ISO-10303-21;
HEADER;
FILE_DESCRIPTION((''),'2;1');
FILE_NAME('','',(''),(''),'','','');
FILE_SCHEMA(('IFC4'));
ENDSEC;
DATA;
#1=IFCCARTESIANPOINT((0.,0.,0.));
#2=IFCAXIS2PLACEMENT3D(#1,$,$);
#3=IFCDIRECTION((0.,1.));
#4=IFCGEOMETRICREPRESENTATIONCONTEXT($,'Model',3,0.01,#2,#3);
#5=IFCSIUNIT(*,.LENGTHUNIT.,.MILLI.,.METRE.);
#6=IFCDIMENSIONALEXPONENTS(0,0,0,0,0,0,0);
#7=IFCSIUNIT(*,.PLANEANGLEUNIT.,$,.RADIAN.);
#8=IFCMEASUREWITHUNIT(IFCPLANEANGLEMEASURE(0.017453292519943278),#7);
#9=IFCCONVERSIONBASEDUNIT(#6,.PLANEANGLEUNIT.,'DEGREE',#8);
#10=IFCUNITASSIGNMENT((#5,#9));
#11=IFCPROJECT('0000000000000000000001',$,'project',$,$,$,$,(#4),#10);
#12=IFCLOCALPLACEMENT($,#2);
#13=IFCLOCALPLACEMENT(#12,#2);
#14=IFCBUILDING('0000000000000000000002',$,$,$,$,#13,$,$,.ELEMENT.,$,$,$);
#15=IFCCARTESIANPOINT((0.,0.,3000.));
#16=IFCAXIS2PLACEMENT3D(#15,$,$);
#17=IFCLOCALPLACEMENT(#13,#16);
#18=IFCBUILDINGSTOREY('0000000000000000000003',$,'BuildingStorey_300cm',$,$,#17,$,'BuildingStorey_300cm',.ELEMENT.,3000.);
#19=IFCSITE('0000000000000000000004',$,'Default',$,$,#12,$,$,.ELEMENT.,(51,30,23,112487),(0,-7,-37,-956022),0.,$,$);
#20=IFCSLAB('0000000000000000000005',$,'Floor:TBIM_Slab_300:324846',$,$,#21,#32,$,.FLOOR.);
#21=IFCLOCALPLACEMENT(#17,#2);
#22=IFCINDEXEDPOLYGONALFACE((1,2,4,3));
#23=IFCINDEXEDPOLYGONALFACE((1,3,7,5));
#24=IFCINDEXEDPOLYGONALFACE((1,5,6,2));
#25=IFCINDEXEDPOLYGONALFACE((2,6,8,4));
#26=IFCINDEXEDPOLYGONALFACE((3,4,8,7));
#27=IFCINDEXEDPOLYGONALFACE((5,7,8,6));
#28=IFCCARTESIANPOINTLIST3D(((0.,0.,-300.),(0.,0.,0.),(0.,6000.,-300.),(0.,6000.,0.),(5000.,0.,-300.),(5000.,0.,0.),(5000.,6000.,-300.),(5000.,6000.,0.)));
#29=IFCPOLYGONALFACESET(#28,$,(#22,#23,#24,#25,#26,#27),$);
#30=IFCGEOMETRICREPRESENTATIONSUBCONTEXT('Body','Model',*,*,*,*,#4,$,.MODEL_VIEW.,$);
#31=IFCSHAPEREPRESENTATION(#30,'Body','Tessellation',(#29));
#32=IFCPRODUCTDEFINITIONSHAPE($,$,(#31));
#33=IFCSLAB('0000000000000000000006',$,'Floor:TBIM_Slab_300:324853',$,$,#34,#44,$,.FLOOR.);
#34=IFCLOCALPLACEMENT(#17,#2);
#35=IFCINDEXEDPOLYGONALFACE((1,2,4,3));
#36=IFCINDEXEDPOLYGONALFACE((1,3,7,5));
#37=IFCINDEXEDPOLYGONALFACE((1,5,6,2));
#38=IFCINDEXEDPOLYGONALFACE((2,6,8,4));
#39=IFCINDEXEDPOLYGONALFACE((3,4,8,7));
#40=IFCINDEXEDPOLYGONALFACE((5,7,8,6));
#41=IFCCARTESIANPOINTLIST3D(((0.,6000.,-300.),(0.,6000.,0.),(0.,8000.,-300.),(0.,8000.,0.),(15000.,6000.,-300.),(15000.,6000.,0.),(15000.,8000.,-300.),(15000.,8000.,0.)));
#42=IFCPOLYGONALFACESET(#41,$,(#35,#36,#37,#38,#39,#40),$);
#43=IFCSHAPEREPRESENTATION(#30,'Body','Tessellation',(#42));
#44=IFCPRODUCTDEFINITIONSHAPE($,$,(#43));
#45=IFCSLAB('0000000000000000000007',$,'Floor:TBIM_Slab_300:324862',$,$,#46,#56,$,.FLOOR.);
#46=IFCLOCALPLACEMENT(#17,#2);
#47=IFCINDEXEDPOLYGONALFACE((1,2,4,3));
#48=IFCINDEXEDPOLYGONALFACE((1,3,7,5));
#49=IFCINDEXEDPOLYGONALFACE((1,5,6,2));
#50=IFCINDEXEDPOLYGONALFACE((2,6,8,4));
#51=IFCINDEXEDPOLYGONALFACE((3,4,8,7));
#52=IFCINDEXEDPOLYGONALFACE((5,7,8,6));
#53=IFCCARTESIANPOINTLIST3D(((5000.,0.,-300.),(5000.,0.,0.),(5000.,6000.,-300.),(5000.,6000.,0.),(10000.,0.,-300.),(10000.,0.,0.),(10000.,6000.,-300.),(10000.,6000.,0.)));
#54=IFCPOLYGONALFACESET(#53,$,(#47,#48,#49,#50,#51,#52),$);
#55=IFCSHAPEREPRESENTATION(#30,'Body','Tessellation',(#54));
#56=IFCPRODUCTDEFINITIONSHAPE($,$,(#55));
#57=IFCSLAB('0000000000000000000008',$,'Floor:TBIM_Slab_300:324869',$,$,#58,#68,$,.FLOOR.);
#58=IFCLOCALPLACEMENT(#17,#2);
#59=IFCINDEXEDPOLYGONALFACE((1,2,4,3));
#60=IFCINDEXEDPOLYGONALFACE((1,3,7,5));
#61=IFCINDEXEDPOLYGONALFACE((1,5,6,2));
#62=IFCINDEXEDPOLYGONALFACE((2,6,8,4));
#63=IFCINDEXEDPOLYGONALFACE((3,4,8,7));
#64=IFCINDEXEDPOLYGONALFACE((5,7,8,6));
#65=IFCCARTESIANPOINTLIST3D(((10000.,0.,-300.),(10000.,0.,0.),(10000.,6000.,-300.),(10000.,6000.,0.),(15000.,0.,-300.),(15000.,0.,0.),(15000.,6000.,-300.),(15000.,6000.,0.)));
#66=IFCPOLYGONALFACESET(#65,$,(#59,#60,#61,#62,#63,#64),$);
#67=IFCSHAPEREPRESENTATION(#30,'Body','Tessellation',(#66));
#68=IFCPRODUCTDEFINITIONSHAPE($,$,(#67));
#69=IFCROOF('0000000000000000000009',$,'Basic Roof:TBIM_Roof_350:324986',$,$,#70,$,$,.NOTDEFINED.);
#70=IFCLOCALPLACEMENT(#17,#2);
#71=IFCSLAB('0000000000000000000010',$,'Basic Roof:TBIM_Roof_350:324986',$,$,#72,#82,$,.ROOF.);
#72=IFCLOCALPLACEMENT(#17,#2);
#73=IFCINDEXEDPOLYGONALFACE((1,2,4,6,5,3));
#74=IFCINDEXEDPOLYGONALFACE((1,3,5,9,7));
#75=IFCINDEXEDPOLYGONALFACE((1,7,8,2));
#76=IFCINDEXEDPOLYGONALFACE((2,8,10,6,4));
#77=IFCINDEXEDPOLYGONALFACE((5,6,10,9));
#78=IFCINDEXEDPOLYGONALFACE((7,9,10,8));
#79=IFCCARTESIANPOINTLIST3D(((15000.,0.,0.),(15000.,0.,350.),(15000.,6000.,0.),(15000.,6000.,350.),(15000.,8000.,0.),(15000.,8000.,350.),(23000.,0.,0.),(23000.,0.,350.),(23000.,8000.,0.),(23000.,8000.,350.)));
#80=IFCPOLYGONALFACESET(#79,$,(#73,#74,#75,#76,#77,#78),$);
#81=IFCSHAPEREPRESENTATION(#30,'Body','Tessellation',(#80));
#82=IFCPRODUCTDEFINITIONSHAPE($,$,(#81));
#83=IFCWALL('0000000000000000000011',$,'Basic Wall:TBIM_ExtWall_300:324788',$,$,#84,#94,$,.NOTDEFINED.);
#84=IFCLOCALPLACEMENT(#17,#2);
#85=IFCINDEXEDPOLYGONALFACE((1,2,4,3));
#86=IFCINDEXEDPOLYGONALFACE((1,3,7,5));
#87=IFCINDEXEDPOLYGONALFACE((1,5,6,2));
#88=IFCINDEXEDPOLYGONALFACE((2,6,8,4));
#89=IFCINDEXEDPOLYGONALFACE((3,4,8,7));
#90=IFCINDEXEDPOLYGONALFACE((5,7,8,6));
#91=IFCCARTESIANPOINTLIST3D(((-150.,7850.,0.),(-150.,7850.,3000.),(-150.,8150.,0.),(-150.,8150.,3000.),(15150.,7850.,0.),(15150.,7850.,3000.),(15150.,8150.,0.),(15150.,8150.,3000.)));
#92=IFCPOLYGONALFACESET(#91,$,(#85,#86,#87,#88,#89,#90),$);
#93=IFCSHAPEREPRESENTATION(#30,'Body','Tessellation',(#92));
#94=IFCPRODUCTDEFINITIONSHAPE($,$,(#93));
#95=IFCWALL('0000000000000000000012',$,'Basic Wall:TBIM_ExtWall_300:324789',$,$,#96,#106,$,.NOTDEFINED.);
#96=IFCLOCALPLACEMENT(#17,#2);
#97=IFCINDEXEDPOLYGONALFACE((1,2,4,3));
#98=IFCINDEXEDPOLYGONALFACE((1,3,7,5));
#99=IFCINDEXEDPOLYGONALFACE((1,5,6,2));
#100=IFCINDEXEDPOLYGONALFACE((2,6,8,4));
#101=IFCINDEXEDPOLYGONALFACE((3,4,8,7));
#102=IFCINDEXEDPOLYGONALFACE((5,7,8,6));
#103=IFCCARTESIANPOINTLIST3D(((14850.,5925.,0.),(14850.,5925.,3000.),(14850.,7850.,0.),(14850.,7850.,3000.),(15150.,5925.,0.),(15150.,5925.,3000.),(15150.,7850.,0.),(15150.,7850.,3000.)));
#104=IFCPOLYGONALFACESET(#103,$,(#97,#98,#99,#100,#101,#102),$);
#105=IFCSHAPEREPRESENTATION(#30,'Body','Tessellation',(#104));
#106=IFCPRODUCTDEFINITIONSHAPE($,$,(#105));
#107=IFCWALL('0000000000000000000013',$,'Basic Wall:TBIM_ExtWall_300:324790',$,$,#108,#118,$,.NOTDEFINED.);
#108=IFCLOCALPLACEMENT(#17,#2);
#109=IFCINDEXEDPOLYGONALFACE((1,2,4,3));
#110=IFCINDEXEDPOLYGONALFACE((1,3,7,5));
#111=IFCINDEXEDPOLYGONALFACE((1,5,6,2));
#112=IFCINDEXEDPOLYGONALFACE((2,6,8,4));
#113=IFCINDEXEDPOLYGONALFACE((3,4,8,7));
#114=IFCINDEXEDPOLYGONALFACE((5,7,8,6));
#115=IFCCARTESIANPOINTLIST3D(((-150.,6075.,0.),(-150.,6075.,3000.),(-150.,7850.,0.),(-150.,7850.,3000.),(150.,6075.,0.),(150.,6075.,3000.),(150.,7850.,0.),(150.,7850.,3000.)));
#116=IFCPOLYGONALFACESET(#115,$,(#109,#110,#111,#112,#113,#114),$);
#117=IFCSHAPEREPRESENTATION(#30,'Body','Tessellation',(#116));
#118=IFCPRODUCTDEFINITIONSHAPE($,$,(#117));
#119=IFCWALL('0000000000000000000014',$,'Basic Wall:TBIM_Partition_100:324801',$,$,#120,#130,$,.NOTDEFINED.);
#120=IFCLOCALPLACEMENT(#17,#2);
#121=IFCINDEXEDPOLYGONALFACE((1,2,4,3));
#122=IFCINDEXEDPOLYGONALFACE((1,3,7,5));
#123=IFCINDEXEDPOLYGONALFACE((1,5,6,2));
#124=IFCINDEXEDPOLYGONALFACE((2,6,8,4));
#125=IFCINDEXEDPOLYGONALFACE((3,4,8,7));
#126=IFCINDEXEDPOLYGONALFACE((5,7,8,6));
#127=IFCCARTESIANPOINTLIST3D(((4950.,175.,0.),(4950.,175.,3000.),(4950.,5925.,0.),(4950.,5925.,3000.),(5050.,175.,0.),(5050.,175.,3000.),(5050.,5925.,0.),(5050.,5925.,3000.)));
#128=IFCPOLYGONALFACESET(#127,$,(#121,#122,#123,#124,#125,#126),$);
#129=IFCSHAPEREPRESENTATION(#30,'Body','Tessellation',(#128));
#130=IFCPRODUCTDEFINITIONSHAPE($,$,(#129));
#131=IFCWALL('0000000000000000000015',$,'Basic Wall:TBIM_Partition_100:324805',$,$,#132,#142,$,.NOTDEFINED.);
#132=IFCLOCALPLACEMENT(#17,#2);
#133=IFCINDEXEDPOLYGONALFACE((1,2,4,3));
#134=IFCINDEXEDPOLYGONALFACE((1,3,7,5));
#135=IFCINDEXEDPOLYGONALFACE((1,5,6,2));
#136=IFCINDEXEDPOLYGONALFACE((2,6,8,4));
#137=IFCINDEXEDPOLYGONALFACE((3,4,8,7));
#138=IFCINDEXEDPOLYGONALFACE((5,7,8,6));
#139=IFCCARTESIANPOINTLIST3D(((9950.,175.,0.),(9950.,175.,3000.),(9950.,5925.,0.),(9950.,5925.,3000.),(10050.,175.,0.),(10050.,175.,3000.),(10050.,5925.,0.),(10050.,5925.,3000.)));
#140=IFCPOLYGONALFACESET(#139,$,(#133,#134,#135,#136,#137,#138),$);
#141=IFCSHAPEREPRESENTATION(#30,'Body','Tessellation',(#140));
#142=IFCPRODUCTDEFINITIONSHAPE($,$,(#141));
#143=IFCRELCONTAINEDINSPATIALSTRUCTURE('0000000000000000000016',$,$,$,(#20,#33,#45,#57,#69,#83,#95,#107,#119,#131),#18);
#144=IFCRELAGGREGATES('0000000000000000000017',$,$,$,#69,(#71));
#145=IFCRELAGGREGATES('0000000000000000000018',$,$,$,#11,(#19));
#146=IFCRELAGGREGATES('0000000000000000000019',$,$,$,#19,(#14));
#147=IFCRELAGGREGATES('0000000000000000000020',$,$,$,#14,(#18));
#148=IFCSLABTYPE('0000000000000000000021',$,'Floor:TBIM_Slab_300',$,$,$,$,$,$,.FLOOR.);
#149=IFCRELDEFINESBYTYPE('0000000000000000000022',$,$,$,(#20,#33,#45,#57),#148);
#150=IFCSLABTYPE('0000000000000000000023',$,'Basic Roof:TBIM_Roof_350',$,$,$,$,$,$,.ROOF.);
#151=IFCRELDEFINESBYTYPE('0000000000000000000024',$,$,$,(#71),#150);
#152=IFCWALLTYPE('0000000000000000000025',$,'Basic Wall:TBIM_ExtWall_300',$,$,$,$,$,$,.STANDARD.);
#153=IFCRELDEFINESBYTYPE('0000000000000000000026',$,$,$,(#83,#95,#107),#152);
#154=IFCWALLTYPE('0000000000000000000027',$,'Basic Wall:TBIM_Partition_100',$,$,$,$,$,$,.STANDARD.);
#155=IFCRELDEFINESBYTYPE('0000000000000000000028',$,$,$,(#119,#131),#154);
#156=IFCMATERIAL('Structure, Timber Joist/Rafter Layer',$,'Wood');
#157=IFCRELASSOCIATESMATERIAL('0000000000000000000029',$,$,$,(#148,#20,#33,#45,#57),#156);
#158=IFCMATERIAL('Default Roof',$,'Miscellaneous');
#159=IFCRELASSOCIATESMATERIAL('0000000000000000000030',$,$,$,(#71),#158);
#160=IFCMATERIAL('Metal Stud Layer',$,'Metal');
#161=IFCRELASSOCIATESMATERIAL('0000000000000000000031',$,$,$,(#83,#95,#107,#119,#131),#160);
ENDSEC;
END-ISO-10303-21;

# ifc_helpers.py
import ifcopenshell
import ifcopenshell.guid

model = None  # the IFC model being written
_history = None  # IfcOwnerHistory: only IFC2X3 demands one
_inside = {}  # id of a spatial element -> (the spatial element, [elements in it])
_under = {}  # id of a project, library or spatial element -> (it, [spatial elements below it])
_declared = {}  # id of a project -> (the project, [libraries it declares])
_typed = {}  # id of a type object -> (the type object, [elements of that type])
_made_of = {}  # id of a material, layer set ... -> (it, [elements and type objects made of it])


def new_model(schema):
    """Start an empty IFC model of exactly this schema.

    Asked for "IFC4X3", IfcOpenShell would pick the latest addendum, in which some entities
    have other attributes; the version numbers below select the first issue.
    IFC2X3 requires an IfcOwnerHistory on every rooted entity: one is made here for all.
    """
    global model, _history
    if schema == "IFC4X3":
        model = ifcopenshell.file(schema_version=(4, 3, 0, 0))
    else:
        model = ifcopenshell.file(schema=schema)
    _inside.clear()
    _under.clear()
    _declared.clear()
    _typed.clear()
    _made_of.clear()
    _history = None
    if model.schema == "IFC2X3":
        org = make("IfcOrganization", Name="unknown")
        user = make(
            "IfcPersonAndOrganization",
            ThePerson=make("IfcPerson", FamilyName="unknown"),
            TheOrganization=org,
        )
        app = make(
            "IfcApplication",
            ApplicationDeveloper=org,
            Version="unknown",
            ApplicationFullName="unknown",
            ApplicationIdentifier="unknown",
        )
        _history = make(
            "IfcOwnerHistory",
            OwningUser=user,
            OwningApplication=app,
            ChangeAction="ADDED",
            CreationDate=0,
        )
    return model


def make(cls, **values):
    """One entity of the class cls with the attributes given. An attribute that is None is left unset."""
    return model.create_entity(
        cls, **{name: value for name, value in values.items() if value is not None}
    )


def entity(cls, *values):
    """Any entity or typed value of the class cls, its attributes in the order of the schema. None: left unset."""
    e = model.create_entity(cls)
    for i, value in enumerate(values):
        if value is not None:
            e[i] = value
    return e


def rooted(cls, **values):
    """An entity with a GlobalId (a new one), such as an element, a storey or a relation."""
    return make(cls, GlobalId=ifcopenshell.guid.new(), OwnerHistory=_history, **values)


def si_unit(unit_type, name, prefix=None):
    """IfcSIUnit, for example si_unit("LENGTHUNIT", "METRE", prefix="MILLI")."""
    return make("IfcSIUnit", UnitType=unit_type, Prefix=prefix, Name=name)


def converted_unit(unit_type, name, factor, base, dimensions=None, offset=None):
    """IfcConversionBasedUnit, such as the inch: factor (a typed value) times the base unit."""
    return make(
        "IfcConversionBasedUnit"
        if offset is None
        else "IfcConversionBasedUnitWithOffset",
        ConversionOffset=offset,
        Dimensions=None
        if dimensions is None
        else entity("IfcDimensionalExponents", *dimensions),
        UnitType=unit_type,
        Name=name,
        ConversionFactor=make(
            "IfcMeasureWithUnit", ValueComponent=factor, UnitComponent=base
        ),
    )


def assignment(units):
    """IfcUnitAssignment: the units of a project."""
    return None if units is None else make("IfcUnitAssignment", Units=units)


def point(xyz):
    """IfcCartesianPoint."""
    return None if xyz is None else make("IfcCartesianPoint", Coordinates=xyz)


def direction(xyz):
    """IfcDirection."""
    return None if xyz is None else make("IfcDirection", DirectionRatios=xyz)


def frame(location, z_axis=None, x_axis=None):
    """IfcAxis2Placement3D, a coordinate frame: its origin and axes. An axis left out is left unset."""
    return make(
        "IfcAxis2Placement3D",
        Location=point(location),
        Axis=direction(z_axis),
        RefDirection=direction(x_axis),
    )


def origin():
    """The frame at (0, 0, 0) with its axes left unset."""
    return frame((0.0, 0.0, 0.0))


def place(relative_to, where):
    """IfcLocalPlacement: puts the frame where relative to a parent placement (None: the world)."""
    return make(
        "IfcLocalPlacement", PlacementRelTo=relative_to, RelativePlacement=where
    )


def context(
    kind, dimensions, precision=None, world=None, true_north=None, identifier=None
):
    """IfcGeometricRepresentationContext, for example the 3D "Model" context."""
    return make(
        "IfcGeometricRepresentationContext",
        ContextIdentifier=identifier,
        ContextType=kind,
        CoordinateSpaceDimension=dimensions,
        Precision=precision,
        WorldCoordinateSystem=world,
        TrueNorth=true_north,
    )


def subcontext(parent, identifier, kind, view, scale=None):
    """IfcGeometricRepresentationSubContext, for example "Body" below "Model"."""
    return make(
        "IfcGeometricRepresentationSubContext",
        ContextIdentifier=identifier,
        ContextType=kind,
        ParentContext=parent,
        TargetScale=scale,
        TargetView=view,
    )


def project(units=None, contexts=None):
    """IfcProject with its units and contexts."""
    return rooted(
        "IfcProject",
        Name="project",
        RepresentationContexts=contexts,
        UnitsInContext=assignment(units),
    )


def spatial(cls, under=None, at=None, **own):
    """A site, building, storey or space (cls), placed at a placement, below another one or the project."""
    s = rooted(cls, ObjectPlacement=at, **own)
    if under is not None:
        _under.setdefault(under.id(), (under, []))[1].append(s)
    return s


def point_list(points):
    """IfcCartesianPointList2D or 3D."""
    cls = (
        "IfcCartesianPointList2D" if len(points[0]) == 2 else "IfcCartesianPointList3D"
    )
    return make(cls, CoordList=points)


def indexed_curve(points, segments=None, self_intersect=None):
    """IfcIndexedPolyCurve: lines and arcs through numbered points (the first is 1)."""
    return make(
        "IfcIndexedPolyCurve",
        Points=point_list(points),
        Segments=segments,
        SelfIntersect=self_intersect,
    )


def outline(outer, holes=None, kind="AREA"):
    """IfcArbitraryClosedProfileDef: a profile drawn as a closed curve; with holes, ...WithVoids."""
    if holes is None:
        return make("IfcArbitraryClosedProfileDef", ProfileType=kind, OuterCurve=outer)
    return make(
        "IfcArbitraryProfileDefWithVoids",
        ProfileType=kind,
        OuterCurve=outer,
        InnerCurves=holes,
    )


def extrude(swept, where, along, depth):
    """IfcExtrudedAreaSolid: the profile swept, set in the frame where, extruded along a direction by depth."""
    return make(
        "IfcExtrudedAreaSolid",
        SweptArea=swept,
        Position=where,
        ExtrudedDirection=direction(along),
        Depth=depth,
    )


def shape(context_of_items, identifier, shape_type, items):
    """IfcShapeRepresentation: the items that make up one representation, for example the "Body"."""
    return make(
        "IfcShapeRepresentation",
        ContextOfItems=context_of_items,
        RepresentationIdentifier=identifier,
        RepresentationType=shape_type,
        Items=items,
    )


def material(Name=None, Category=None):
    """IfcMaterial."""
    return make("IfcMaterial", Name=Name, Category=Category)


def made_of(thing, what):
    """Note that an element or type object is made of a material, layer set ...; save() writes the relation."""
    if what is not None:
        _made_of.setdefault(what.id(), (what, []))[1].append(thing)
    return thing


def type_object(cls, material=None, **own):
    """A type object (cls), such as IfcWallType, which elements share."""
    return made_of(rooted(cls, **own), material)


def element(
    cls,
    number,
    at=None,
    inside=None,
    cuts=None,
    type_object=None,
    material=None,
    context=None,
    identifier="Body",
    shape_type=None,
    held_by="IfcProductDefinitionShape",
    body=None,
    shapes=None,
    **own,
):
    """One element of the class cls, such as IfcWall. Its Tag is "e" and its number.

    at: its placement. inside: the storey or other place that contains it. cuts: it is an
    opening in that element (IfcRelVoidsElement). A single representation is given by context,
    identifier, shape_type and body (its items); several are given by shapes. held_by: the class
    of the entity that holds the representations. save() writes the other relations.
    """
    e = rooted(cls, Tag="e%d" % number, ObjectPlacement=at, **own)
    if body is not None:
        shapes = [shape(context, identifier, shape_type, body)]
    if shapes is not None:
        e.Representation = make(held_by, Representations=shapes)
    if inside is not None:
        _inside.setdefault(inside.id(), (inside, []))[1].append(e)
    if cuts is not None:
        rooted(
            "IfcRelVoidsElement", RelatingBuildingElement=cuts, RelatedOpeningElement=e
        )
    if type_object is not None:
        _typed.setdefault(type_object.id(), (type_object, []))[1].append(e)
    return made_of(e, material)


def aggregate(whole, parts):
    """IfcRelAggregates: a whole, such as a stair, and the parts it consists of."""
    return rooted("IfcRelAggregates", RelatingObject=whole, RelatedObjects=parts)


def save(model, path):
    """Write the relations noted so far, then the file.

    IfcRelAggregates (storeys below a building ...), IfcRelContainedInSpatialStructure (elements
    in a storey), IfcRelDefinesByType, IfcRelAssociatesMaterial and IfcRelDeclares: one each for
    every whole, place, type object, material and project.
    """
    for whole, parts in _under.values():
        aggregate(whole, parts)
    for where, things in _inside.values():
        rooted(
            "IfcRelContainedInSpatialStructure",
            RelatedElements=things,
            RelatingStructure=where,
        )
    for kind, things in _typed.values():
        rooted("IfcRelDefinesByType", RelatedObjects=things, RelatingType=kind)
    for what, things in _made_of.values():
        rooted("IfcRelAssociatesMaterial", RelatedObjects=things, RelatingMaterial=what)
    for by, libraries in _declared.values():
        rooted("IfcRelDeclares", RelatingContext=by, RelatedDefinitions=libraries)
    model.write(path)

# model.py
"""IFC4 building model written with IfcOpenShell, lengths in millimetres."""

from ifc_helpers import new_model, entity, si_unit, converted_unit, direction, frame, origin, place, context, subcontext, project, spatial, indexed_curve, outline, extrude, material, type_object, element, aggregate, save


model = new_model("IFC4")

# Units and contexts
model_context = context("Model", 3, precision=0.01, world=origin(), true_north=direction((0.0, 1.0)))
body_context = subcontext(model_context, "Body", "Model", "MODEL_VIEW")
ifc_project = project(units=[si_unit("LENGTHUNIT", "METRE", prefix="MILLI"), converted_unit("PLANEANGLEUNIT", "DEGREE", entity("IfcPlaneAngleMeasure", 0.017453292519943278), si_unit("PLANEANGLEUNIT", "RADIAN"), dimensions=[0, 0, 0, 0, 0, 0, 0])], contexts=[model_context])

# Site, building, storey
site_placement = place(None, origin())
site = spatial("IfcSite", under=ifc_project, at=site_placement, Name="Default", CompositionType="ELEMENT", RefLatitude=(51, 30, 23, 112487), RefLongitude=(0, -7, -37, -956022), RefElevation=0.0)
building_placement = place(site_placement, origin())
building = spatial("IfcBuilding", under=site, at=building_placement, CompositionType="ELEMENT")
storey_placement = place(building_placement, frame((0.0, 0.0, 3000.0)))
storey = spatial("IfcBuildingStorey", under=building, at=storey_placement, Name="BuildingStorey_300cm", LongName="BuildingStorey_300cm", CompositionType="ELEMENT", Elevation=3000.0)

# Slabs
ifc_material_1 = material(Name="Structure, Timber Joist/Rafter Layer", Category="Wood")
slab_type_1 = type_object("IfcSlabType", Name="Floor:TBIM_Slab_300", PredefinedType="FLOOR", material=ifc_material_1)
slab_1_placement = place(storey_placement, origin())
element("IfcSlab", 1, at=slab_1_placement, inside=storey, type_object=slab_type_1, material=ifc_material_1, Name="Floor:TBIM_Slab_300:324846", PredefinedType="FLOOR", context=body_context, shape_type="SweptSolid", body=[
    extrude(outline(indexed_curve([(-3000.0, -2500.0), (3000.0, -2500.0), (3000.0, 2500.0), (-3000.0, 2500.0), (-3000.0, -2500.0)], self_intersect=False)), frame((2500.0, 3000.0, 0.0), z_axis=(0.0, 0.0, -1.0), x_axis=(0.0, 1.0, 0.0)), (0.0, 0.0, 1.0), 300.0),
])
slab_2_placement = place(storey_placement, origin())
element("IfcSlab", 2, at=slab_2_placement, inside=storey, type_object=slab_type_1, material=ifc_material_1, Name="Floor:TBIM_Slab_300:324853", PredefinedType="FLOOR", context=body_context, shape_type="SweptSolid", body=[
    extrude(outline(indexed_curve([(-1000.0, -7500.0), (1000.0, -7500.0), (1000.0, 7500.0), (-1000.0, 7500.0), (-1000.0, -7500.0)], self_intersect=False)), frame((7500.0, 7000.0, 0.0), z_axis=(0.0, 0.0, -1.0), x_axis=(0.0, 1.0, 0.0)), (0.0, 0.0, 1.0), 300.0),
])
slab_3_placement = place(storey_placement, origin())
element("IfcSlab", 3, at=slab_3_placement, inside=storey, type_object=slab_type_1, material=ifc_material_1, Name="Floor:TBIM_Slab_300:324862", PredefinedType="FLOOR", context=body_context, shape_type="SweptSolid", body=[
    extrude(outline(indexed_curve([(-3000.0, -2500.0), (3000.0, -2500.0), (3000.0, 2500.0), (-3000.0, 2500.0), (-3000.0, -2500.0)], self_intersect=False)), frame((7500.0, 3000.0, 0.0), z_axis=(0.0, 0.0, -1.0), x_axis=(0.0, 1.0, 0.0)), (0.0, 0.0, 1.0), 300.0),
])
slab_4_placement = place(storey_placement, origin())
element("IfcSlab", 4, at=slab_4_placement, inside=storey, type_object=slab_type_1, material=ifc_material_1, Name="Floor:TBIM_Slab_300:324869", PredefinedType="FLOOR", context=body_context, shape_type="SweptSolid", body=[
    extrude(outline(indexed_curve([(-3000.0, -2500.0), (3000.0, -2500.0), (3000.0, 2500.0), (-3000.0, 2500.0), (-3000.0, -2500.0)], self_intersect=False)), frame((12500.0, 3000.0, 0.0), z_axis=(0.0, 0.0, -1.0), x_axis=(0.0, 1.0, 0.0)), (0.0, 0.0, 1.0), 300.0),
])

# Roof, slab
roof_placement = place(storey_placement, frame((15000.0, 0.0, 0.0)))
roof = element("IfcRoof", 5, at=roof_placement, inside=storey, Name="Basic Roof:TBIM_Roof_350:324986", PredefinedType="NOTDEFINED")
ifc_material_2 = material(Name="Default Roof", Category="Miscellaneous")
slab_type_2 = type_object("IfcSlabType", Name="Basic Roof:TBIM_Roof_350", PredefinedType="ROOF")
slab_5_placement = place(roof_placement, origin())
slab_5 = element("IfcSlab", 6, at=slab_5_placement, type_object=slab_type_2, material=ifc_material_2, Name="Basic Roof:TBIM_Roof_350:324986", PredefinedType="ROOF", context=body_context, shape_type="SweptSolid", body=[
    extrude(outline(indexed_curve([(-4000.0, 4000.0), (-4000.0, 2000.0), (-4000.0, -4000.0), (4000.0, -4000.0), (4000.0, 4000.0), (-4000.0, 4000.0)], self_intersect=False)), frame((4000.0, 4000.0, 0.0)), (0.0, 0.0, 1.0), 350.0),
])
aggregate(roof, [slab_5])

# Walls
ifc_material_3 = material(Name="Metal Stud Layer", Category="Metal")
wall_type_1 = type_object("IfcWallType", Name="Basic Wall:TBIM_ExtWall_300", PredefinedType="STANDARD")
wall_1_placement = place(storey_placement, frame((-150.0, 8000.0, 0.0)))
element("IfcWall", 7, at=wall_1_placement, inside=storey, type_object=wall_type_1, material=ifc_material_3, Name="Basic Wall:TBIM_ExtWall_300:324788", PredefinedType="NOTDEFINED", context=body_context, shape_type="SweptSolid", body=[
    extrude(outline(indexed_curve([(15300.0, 150.0), (0.0, 150.0), (0.0, -150.0), (15300.0, -150.0), (15300.0, 150.0)], self_intersect=False)), origin(), (0.0, 0.0, 1.0), 3000.0),
])
wall_2_placement = place(storey_placement, frame((15000.0, 7850.0, 0.0), z_axis=(0.0, 0.0, 1.0), x_axis=(0.0, -1.0, 0.0)))
element("IfcWall", 8, at=wall_2_placement, inside=storey, type_object=wall_type_1, material=ifc_material_3, Name="Basic Wall:TBIM_ExtWall_300:324789", PredefinedType="NOTDEFINED", context=body_context, shape_type="SweptSolid", body=[
    extrude(outline(indexed_curve([(1925.0, 150.0), (0.0, 150.0), (0.0, -150.0), (1925.0, -150.0), (1925.0, 150.0)], self_intersect=False)), origin(), (0.0, 0.0, 1.0), 3000.0),
])
wall_3_placement = place(storey_placement, frame((0.0, 7850.0, 0.0), z_axis=(0.0, 0.0, 1.0), x_axis=(0.0, -1.0, 0.0)))
element("IfcWall", 9, at=wall_3_placement, inside=storey, type_object=wall_type_1, material=ifc_material_3, Name="Basic Wall:TBIM_ExtWall_300:324790", PredefinedType="NOTDEFINED", context=body_context, shape_type="SweptSolid", body=[
    extrude(outline(indexed_curve([(1775.0, 150.0), (0.0, 150.0), (0.0, -150.0), (1775.0, -150.0), (1775.0, 150.0)], self_intersect=False)), origin(), (0.0, 0.0, 1.0), 3000.0),
])
wall_type_2 = type_object("IfcWallType", Name="Basic Wall:TBIM_Partition_100", PredefinedType="STANDARD")
wall_4_placement = place(storey_placement, frame((5000.0, 175.0, 0.0), z_axis=(0.0, 0.0, 1.0), x_axis=(0.0, 1.0, 0.0)))
element("IfcWall", 10, at=wall_4_placement, inside=storey, type_object=wall_type_2, material=ifc_material_3, Name="Basic Wall:TBIM_Partition_100:324801", PredefinedType="NOTDEFINED", context=body_context, shape_type="SweptSolid", body=[
    extrude(outline(indexed_curve([(5750.0, 50.0), (0.0, 50.0), (0.0, -50.0), (5750.0, -50.0), (5750.0, 50.0)], self_intersect=False)), origin(), (0.0, 0.0, 1.0), 3000.0),
])
wall_5_placement = place(storey_placement, frame((10000.0, 175.0, 0.0), z_axis=(0.0, 0.0, 1.0), x_axis=(0.0, 1.0, 0.0)))
element("IfcWall", 11, at=wall_5_placement, inside=storey, type_object=wall_type_2, material=ifc_material_3, Name="Basic Wall:TBIM_Partition_100:324805", PredefinedType="NOTDEFINED", context=body_context, shape_type="SweptSolid", body=[
    extrude(outline(indexed_curve([(5750.0, 50.0), (0.0, 50.0), (0.0, -50.0), (5750.0, -50.0), (5750.0, 50.0)], self_intersect=False)), origin(), (0.0, 0.0, 1.0), 3000.0),
])

save(model, "model.ifc")
